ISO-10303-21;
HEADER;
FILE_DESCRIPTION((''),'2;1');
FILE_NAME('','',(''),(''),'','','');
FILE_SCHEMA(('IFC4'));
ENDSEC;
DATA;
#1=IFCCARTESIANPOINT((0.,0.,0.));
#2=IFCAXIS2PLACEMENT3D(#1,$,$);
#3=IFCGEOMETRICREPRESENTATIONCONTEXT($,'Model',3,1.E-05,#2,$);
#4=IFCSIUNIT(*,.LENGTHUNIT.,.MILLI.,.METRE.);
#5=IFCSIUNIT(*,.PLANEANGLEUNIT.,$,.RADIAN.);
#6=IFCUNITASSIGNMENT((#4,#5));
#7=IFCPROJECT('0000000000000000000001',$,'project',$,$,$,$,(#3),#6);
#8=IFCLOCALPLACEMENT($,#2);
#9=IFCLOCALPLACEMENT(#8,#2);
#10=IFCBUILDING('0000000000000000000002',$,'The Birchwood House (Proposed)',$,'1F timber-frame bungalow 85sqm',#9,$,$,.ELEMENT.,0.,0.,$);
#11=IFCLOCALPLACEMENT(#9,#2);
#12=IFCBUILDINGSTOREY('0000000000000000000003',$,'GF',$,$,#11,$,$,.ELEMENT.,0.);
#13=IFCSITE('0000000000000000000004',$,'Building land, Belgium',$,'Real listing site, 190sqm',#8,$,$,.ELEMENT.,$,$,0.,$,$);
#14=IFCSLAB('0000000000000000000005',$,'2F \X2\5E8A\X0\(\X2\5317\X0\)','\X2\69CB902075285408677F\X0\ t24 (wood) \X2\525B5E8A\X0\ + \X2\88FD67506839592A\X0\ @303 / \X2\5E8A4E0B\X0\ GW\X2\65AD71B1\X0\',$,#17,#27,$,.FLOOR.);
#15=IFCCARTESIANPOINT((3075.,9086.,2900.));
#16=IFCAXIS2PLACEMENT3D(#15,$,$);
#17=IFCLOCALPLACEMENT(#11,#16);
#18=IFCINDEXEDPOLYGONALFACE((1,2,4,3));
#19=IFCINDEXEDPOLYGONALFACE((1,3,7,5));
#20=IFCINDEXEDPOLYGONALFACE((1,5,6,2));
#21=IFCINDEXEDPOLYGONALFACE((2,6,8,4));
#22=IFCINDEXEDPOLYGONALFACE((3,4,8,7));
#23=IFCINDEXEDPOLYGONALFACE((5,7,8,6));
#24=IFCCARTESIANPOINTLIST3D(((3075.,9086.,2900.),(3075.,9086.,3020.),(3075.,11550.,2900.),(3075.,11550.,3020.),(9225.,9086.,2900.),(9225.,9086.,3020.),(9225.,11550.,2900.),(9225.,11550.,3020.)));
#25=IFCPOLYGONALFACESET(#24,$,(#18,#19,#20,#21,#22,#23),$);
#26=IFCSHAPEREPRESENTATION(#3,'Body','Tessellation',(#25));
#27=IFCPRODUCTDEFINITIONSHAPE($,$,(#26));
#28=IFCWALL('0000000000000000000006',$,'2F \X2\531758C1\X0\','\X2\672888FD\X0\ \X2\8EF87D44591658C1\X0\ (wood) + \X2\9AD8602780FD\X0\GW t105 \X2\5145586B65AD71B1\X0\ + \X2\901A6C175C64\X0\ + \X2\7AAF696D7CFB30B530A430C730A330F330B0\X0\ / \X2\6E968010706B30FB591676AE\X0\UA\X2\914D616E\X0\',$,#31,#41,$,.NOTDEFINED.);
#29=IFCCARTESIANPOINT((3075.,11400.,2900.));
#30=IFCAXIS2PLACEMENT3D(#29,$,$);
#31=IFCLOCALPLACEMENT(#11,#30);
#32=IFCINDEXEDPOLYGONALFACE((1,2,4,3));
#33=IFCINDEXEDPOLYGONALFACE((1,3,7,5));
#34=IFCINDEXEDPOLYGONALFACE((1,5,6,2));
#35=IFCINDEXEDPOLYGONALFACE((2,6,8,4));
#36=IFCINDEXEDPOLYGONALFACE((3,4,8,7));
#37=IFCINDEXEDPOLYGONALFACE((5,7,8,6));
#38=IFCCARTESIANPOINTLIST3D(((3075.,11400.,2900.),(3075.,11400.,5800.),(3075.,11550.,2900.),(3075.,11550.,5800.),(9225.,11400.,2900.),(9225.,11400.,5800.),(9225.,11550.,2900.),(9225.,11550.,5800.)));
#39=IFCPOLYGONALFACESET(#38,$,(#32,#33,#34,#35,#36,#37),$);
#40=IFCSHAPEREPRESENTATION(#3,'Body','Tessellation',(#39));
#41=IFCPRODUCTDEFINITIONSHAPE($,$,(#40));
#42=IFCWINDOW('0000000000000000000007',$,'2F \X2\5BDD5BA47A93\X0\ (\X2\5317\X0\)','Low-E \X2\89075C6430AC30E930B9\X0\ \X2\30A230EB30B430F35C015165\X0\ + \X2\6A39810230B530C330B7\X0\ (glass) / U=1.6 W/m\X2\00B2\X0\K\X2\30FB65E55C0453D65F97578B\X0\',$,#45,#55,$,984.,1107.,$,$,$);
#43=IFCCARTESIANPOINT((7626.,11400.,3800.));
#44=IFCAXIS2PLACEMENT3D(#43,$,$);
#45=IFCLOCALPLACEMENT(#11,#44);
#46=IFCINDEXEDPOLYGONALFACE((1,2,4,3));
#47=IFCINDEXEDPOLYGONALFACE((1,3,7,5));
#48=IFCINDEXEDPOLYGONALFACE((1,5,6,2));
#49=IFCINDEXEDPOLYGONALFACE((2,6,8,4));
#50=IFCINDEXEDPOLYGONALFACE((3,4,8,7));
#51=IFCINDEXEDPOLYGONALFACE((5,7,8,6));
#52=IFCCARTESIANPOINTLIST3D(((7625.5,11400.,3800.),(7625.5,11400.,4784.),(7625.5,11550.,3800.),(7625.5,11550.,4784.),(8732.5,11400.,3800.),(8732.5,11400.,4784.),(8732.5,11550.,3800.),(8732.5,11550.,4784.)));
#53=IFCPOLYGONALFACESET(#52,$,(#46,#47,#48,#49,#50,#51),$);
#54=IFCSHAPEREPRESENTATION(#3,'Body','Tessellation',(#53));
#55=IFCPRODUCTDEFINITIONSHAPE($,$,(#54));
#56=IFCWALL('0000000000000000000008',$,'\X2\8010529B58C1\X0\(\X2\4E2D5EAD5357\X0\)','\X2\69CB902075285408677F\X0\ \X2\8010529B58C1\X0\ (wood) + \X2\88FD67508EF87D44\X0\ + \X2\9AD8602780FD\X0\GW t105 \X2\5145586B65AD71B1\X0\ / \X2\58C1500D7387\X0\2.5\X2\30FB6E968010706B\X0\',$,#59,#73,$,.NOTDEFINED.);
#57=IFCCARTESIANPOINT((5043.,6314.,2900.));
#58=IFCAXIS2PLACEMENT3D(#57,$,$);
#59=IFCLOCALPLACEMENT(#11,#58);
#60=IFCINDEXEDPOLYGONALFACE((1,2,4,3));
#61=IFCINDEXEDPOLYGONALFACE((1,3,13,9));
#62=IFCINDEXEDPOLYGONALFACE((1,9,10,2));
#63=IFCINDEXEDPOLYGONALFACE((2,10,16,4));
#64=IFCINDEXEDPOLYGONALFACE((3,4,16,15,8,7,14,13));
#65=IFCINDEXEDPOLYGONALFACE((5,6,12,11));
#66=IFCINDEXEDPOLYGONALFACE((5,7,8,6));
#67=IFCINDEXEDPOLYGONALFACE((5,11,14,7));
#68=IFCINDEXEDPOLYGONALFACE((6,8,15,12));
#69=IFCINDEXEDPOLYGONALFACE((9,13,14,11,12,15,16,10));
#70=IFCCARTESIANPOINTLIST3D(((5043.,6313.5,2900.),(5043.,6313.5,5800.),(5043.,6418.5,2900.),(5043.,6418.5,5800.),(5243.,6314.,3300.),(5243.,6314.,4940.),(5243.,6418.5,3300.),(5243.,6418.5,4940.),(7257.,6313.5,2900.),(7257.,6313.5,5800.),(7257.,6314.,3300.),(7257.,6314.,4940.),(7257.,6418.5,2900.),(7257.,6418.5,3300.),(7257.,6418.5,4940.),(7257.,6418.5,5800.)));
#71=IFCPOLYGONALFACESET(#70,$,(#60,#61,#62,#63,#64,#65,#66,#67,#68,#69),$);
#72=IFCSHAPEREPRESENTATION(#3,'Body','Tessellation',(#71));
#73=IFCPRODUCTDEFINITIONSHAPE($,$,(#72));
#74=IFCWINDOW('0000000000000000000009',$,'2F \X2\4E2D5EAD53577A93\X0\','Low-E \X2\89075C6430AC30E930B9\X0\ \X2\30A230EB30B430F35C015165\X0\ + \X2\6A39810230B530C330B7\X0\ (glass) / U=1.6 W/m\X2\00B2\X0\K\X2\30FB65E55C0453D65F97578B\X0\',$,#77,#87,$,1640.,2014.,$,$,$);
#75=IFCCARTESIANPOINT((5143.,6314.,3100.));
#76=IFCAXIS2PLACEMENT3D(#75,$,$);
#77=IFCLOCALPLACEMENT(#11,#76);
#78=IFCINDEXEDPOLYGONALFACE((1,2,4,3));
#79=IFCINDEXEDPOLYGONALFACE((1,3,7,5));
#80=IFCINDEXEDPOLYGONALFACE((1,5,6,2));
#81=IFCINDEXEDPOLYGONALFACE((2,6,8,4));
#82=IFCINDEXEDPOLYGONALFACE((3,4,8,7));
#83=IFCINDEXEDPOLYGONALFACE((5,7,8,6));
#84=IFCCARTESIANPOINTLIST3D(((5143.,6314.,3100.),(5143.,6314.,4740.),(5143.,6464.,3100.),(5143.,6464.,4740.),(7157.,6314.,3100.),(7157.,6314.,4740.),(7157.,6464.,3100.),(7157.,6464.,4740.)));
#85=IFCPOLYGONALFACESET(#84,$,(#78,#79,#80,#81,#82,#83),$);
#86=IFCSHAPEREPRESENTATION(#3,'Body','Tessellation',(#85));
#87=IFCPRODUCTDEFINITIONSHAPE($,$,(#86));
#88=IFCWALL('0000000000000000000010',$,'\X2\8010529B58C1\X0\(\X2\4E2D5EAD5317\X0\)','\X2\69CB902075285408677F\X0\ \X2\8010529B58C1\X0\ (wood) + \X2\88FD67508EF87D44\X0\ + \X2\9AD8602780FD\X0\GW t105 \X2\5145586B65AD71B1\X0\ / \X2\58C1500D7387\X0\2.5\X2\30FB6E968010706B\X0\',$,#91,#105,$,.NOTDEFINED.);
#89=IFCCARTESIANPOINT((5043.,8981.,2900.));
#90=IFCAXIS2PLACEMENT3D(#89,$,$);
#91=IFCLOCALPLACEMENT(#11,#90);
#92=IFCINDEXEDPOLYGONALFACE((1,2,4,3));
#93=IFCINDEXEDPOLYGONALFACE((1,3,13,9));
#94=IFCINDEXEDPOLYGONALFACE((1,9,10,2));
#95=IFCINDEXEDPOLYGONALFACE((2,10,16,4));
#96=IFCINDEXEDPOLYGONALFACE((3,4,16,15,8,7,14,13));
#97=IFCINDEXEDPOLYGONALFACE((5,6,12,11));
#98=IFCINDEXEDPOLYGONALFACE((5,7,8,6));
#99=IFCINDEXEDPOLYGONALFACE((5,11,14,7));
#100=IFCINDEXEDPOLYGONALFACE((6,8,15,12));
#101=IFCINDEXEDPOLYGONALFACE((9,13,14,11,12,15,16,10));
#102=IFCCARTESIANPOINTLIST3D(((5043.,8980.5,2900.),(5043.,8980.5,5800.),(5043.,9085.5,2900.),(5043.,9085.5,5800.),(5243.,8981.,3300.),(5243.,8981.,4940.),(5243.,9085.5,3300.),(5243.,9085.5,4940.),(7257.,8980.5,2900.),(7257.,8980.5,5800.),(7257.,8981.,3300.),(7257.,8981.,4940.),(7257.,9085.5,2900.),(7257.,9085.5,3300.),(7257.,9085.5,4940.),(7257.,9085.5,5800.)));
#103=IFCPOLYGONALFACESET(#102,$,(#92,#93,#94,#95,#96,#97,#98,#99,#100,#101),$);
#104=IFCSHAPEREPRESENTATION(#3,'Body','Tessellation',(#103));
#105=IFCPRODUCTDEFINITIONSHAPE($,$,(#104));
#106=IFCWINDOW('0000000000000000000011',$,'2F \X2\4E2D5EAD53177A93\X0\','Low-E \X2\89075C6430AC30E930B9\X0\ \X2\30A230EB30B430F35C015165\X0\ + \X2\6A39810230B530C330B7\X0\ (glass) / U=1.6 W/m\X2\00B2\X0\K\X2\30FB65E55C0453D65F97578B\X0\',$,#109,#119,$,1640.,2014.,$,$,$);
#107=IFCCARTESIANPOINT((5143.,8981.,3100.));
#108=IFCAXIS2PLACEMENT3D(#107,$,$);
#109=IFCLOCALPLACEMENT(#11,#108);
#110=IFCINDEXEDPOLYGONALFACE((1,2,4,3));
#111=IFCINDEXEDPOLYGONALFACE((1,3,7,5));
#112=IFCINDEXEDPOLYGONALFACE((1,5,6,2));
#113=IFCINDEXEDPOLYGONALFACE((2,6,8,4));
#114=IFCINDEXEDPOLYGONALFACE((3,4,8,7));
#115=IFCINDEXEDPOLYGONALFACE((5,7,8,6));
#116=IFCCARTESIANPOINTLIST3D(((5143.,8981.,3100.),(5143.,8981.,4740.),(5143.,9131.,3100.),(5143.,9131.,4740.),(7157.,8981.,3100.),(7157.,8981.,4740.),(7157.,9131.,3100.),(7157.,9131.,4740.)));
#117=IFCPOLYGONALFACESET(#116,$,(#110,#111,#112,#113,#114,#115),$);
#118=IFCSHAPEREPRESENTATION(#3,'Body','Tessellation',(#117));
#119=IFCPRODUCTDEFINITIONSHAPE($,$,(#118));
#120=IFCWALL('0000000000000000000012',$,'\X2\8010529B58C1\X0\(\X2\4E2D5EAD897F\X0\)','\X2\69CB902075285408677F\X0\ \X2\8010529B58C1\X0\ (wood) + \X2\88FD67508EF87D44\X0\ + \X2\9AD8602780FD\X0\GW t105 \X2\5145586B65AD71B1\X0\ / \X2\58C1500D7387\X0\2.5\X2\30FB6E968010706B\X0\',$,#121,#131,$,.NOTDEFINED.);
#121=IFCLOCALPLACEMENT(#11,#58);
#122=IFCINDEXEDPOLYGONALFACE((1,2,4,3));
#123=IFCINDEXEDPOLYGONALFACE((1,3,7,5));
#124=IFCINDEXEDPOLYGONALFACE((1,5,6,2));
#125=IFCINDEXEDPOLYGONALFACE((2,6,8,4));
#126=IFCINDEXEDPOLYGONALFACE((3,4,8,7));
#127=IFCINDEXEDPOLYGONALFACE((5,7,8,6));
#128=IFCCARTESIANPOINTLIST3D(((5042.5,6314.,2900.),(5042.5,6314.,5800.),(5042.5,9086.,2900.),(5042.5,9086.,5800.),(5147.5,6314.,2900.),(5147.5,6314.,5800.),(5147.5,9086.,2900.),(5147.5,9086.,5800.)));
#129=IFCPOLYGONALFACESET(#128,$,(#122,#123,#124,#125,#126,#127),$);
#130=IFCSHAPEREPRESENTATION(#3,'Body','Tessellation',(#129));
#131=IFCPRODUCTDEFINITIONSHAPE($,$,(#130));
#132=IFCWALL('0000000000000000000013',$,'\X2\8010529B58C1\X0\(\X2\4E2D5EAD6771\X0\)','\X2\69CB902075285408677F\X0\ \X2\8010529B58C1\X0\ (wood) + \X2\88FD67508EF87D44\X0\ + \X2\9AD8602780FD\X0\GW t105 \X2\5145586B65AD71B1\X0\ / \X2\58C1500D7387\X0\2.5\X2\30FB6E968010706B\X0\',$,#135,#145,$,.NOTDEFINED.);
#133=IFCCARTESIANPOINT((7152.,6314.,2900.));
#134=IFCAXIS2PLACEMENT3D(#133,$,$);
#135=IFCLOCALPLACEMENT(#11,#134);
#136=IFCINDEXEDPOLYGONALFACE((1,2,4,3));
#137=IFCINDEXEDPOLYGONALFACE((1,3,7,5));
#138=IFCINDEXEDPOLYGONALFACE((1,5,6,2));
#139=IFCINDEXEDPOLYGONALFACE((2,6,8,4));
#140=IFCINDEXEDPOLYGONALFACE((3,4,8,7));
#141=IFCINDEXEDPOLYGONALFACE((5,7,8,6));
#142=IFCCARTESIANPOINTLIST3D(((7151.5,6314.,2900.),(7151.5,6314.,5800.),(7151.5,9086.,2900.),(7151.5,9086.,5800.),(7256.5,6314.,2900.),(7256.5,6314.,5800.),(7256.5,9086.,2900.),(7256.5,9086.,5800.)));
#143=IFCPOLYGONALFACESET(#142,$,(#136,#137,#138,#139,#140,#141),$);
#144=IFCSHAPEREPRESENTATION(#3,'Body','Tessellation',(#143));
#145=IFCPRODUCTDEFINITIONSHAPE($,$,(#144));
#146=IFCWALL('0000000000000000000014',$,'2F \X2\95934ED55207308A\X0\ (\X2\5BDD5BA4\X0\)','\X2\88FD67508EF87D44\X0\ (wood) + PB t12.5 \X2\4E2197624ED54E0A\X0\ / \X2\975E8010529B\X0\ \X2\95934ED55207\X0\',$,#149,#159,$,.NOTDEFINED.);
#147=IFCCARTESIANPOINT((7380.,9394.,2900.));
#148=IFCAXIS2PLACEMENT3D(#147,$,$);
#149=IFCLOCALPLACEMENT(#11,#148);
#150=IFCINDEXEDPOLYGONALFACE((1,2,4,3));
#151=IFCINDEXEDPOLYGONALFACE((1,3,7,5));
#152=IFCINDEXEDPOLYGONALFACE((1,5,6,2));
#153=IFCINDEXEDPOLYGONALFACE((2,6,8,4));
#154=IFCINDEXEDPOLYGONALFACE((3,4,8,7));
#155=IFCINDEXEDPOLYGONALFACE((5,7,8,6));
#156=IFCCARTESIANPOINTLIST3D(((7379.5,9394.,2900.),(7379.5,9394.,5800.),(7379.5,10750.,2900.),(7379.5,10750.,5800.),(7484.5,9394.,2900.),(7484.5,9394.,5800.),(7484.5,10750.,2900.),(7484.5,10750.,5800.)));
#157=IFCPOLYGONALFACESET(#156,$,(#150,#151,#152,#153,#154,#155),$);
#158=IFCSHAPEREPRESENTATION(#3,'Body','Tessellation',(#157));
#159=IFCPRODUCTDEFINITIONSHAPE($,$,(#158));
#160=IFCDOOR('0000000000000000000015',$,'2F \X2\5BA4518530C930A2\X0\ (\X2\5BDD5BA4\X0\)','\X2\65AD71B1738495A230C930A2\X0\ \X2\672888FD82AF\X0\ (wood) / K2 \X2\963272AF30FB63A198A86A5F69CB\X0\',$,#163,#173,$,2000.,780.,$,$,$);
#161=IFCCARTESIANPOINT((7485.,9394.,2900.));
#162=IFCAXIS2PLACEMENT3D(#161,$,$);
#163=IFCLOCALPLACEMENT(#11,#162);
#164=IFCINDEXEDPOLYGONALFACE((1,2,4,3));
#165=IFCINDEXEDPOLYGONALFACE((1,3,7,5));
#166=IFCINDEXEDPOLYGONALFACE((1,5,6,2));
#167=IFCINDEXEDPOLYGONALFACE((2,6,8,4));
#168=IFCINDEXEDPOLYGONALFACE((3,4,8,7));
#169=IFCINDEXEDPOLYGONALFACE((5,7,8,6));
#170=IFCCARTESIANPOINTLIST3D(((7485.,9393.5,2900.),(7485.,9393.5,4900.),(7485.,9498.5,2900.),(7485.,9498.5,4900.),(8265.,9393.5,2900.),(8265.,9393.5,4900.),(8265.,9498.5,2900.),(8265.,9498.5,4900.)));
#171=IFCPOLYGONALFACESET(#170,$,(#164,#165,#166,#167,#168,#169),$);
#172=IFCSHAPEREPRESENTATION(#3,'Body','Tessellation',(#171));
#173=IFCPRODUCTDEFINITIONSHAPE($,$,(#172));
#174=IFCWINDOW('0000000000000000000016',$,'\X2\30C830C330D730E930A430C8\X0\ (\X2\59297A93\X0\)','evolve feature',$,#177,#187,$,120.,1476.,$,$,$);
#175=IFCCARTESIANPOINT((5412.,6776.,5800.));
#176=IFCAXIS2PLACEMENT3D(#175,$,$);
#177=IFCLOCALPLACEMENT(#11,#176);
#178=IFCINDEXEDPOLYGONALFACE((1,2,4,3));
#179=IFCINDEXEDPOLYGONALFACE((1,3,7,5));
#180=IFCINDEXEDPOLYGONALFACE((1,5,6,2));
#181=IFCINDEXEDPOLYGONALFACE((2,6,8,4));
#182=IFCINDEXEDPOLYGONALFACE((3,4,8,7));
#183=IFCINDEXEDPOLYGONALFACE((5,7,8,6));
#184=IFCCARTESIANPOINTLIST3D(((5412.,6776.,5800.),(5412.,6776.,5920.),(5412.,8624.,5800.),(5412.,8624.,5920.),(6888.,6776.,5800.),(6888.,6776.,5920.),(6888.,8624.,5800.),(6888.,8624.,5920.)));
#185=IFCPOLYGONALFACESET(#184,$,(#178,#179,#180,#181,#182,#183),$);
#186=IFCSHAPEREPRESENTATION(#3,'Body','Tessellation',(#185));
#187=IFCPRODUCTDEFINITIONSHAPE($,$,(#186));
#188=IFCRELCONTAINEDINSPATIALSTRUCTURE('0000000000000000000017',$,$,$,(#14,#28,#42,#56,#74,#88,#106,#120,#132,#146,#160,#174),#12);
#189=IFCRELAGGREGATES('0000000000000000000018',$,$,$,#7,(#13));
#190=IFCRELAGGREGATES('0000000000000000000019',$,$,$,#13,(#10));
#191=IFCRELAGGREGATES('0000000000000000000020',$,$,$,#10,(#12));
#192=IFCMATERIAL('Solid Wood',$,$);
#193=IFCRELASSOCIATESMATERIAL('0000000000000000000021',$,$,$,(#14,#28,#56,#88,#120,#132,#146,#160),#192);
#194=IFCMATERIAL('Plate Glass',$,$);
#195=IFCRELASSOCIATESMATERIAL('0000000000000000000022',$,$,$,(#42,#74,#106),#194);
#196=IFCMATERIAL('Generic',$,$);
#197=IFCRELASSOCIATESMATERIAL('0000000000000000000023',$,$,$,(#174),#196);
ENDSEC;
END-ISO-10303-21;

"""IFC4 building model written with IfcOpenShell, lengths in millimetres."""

from ifc_helpers import new_model, si_unit, frame, frame_2d, origin, place, context, project, spatial, rectangle, extrude, material, element, fill, save


model = new_model("IFC4")

# Units and contexts
model_context = context("Model", 3, precision=1e-05, world=origin())
ifc_project = project(units=[si_unit("LENGTHUNIT", "METRE", prefix="MILLI"), si_unit("PLANEANGLEUNIT", "RADIAN")], contexts=[model_context])

# Site, building, storey
site_placement = place(None, origin())
site = spatial("IfcSite", under=ifc_project, at=site_placement, Name="Building land, Belgium", ObjectType="Real listing site, 190sqm", CompositionType="ELEMENT", RefElevation=0.0)
building_placement = place(site_placement, origin())
building = spatial("IfcBuilding", under=site, at=building_placement, Name="The Birchwood House (Proposed)", ObjectType="1F timber-frame bungalow 85sqm", CompositionType="ELEMENT", ElevationOfRefHeight=0.0, ElevationOfTerrain=0.0)
storey_placement = place(building_placement, origin())
storey = spatial("IfcBuildingStorey", under=building, at=storey_placement, Name="GF", CompositionType="ELEMENT", Elevation=0.0)

# Slab
ifc_material_1 = material(Name="Solid Wood")
slab_placement = place(storey_placement, frame((3075.0, 9086.0, 2900.0)))
element("IfcSlab", 1, at=slab_placement, inside=storey, material=ifc_material_1, Name="2F 床(北)", Description="構造用合板 t24 (wood) 剛床 + 製材根太 @303 / 床下 GW断熱", PredefinedType="FLOOR", context=model_context, shape_type="SweptSolid", body=[
    extrude(rectangle(XDim=6150.0, YDim=2464.0, at=frame_2d((3075.0, 1232.0))), frame((3075.0, 9086.0, 2900.0)), (0.0, 0.0, 1.0), 120.0),
])

# Walls, openings, windows
wall_1_placement = place(storey_placement, frame((3075.0, 11400.0, 2900.0)))
wall_1 = element("IfcWall", 2, at=wall_1_placement, inside=storey, material=ifc_material_1, Name="2F 北壁", Description="木製 軸組外壁 (wood) + 高性能GW t105 充填断熱 + 通気層 + 窯業系サイディング / 準耐火・外皮UA配慮", PredefinedType="NOTDEFINED", context=model_context, shape_type="SweptSolid", body=[
    extrude(rectangle(XDim=6150.0, YDim=150.0, at=frame_2d((3075.0, 75.0))), frame((3075.0, 11400.0, 2900.0)), (0.0, 0.0, 1.0), 2900.0),
])
opening_1_placement = place(storey_placement, frame((7626.0, 11400.0, 3800.0)))
opening_1 = element("IfcOpeningElement", 3, at=opening_1_placement, cuts=wall_1, PredefinedType="NOTDEFINED", context=model_context, shape_type="SweptSolid", body=[
    extrude(rectangle(XDim=1107.0, YDim=150.0, at=frame_2d((553.0, 75.0))), frame((7626.0, 11400.0, 3800.0)), (0.0, 0.0, 1.0), 984.0),
])
ifc_material_2 = material(Name="Plate Glass")
window_1_placement = place(storey_placement, frame((7626.0, 11400.0, 3800.0)))
window_1 = element("IfcWindow", 4, at=window_1_placement, inside=storey, material=ifc_material_2, Name="2F 寝室窓 (北)", Description="Low-E 複層ガラス アルゴン封入 + 樹脂サッシ (glass) / U=1.6 W/m²K・日射取得型", OverallHeight=984.0, OverallWidth=1107.0, context=model_context, shape_type="SweptSolid", body=[
    extrude(rectangle(XDim=1107.0, YDim=150.0, at=frame_2d((553.0, 75.0))), frame((7626.0, 11400.0, 3800.0)), (0.0, 0.0, 1.0), 984.0),
])
fill(opening_1, window_1)
wall_2_placement = place(storey_placement, frame((5043.0, 6314.0, 2900.0)))
wall_2 = element("IfcWall", 5, at=wall_2_placement, inside=storey, material=ifc_material_1, Name="耐力壁(中庭南)", Description="構造用合板 耐力壁 (wood) + 製材軸組 + 高性能GW t105 充填断熱 / 壁倍率2.5・準耐火", PredefinedType="NOTDEFINED", context=model_context, shape_type="SweptSolid", body=[
    extrude(rectangle(XDim=2214.0, YDim=105.0, at=frame_2d((1107.0, 52.0))), frame((5043.0, 6314.0, 2900.0)), (0.0, 0.0, 1.0), 2900.0),
])
opening_2_placement = place(storey_placement, frame((5143.0, 6314.0, 3100.0)))
opening_2 = element("IfcOpeningElement", 6, at=opening_2_placement, cuts=wall_2, PredefinedType="NOTDEFINED", context=model_context, shape_type="SweptSolid", body=[
    extrude(rectangle(XDim=2014.0, YDim=150.0, at=frame_2d((1007.0, 75.0))), frame((5143.0, 6314.0, 3100.0)), (0.0, 0.0, 1.0), 1640.0),
])
window_2_placement = place(storey_placement, frame((5143.0, 6314.0, 3100.0)))
window_2 = element("IfcWindow", 7, at=window_2_placement, inside=storey, material=ifc_material_2, Name="2F 中庭南窓", Description="Low-E 複層ガラス アルゴン封入 + 樹脂サッシ (glass) / U=1.6 W/m²K・日射取得型", OverallHeight=1640.0, OverallWidth=2014.0, context=model_context, shape_type="SweptSolid", body=[
    extrude(rectangle(XDim=2014.0, YDim=150.0, at=frame_2d((1007.0, 75.0))), frame((5143.0, 6314.0, 3100.0)), (0.0, 0.0, 1.0), 1640.0),
])
fill(opening_2, window_2)
wall_3_placement = place(storey_placement, frame((5043.0, 8981.0, 2900.0)))
wall_3 = element("IfcWall", 8, at=wall_3_placement, inside=storey, material=ifc_material_1, Name="耐力壁(中庭北)", Description="構造用合板 耐力壁 (wood) + 製材軸組 + 高性能GW t105 充填断熱 / 壁倍率2.5・準耐火", PredefinedType="NOTDEFINED", context=model_context, shape_type="SweptSolid", body=[
    extrude(rectangle(XDim=2214.0, YDim=105.0, at=frame_2d((1107.0, 52.0))), frame((5043.0, 8981.0, 2900.0)), (0.0, 0.0, 1.0), 2900.0),
])
opening_3_placement = place(storey_placement, frame((5143.0, 8981.0, 3100.0)))
opening_3 = element("IfcOpeningElement", 9, at=opening_3_placement, cuts=wall_3, PredefinedType="NOTDEFINED", context=model_context, shape_type="SweptSolid", body=[
    extrude(rectangle(XDim=2014.0, YDim=150.0, at=frame_2d((1007.0, 75.0))), frame((5143.0, 8981.0, 3100.0)), (0.0, 0.0, 1.0), 1640.0),
])
window_3_placement = place(storey_placement, frame((5143.0, 8981.0, 3100.0)))
window_3 = element("IfcWindow", 10, at=window_3_placement, inside=storey, material=ifc_material_2, Name="2F 中庭北窓", Description="Low-E 複層ガラス アルゴン封入 + 樹脂サッシ (glass) / U=1.6 W/m²K・日射取得型", OverallHeight=1640.0, OverallWidth=2014.0, context=model_context, shape_type="SweptSolid", body=[
    extrude(rectangle(XDim=2014.0, YDim=150.0, at=frame_2d((1007.0, 75.0))), frame((5143.0, 8981.0, 3100.0)), (0.0, 0.0, 1.0), 1640.0),
])
fill(opening_3, window_3)

# Walls
wall_4_placement = place(storey_placement, frame((5043.0, 6314.0, 2900.0)))
element("IfcWall", 11, at=wall_4_placement, inside=storey, material=ifc_material_1, Name="耐力壁(中庭西)", Description="構造用合板 耐力壁 (wood) + 製材軸組 + 高性能GW t105 充填断熱 / 壁倍率2.5・準耐火", PredefinedType="NOTDEFINED", context=model_context, shape_type="SweptSolid", body=[
    extrude(rectangle(XDim=105.0, YDim=2772.0, at=frame_2d((52.0, 1386.0))), frame((5043.0, 6314.0, 2900.0)), (0.0, 0.0, 1.0), 2900.0),
])
wall_5_placement = place(storey_placement, frame((7152.0, 6314.0, 2900.0)))
element("IfcWall", 12, at=wall_5_placement, inside=storey, material=ifc_material_1, Name="耐力壁(中庭東)", Description="構造用合板 耐力壁 (wood) + 製材軸組 + 高性能GW t105 充填断熱 / 壁倍率2.5・準耐火", PredefinedType="NOTDEFINED", context=model_context, shape_type="SweptSolid", body=[
    extrude(rectangle(XDim=105.0, YDim=2772.0, at=frame_2d((52.0, 1386.0))), frame((7152.0, 6314.0, 2900.0)), (0.0, 0.0, 1.0), 2900.0),
])
wall_6_placement = place(storey_placement, frame((7380.0, 9394.0, 2900.0)))
element("IfcWall", 13, at=wall_6_placement, inside=storey, material=ifc_material_1, Name="2F 間仕切り (寝室)", Description="製材軸組 (wood) + PB t12.5 両面仕上 / 非耐力 間仕切", PredefinedType="NOTDEFINED", context=model_context, shape_type="SweptSolid", body=[
    extrude(rectangle(XDim=105.0, YDim=1356.0, at=frame_2d((52.0, 678.0))), frame((7380.0, 9394.0, 2900.0)), (0.0, 0.0, 1.0), 2900.0),
])

# Door
door_placement = place(storey_placement, frame((7485.0, 9394.0, 2900.0)))
element("IfcDoor", 14, at=door_placement, inside=storey, material=ifc_material_1, Name="2F 室内ドア (寝室)", Description="断熱玄関ドア 木製芯 (wood) / K2 防犯・採風機構", OverallHeight=2000.0, OverallWidth=780.0, context=model_context, shape_type="SweptSolid", body=[
    extrude(rectangle(XDim=780.0, YDim=105.0, at=frame_2d((390.0, 52.0))), frame((7485.0, 9394.0, 2900.0)), (0.0, 0.0, 1.0), 2000.0),
])

# Window
ifc_material_3 = material(Name="Generic")
window_4_placement = place(storey_placement, frame((5412.0, 6776.0, 5800.0)))
element("IfcWindow", 15, at=window_4_placement, inside=storey, material=ifc_material_3, Name="トップライト (天窓)", Description="evolve feature", OverallHeight=120.0, OverallWidth=1476.0, context=model_context, shape_type="SweptSolid", body=[
    extrude(rectangle(XDim=1476.0, YDim=1848.0, at=frame_2d((738.0, 924.0))), frame((5412.0, 6776.0, 5800.0)), (0.0, 0.0, 1.0), 120.0),
])

save(model, "model.ifc")
